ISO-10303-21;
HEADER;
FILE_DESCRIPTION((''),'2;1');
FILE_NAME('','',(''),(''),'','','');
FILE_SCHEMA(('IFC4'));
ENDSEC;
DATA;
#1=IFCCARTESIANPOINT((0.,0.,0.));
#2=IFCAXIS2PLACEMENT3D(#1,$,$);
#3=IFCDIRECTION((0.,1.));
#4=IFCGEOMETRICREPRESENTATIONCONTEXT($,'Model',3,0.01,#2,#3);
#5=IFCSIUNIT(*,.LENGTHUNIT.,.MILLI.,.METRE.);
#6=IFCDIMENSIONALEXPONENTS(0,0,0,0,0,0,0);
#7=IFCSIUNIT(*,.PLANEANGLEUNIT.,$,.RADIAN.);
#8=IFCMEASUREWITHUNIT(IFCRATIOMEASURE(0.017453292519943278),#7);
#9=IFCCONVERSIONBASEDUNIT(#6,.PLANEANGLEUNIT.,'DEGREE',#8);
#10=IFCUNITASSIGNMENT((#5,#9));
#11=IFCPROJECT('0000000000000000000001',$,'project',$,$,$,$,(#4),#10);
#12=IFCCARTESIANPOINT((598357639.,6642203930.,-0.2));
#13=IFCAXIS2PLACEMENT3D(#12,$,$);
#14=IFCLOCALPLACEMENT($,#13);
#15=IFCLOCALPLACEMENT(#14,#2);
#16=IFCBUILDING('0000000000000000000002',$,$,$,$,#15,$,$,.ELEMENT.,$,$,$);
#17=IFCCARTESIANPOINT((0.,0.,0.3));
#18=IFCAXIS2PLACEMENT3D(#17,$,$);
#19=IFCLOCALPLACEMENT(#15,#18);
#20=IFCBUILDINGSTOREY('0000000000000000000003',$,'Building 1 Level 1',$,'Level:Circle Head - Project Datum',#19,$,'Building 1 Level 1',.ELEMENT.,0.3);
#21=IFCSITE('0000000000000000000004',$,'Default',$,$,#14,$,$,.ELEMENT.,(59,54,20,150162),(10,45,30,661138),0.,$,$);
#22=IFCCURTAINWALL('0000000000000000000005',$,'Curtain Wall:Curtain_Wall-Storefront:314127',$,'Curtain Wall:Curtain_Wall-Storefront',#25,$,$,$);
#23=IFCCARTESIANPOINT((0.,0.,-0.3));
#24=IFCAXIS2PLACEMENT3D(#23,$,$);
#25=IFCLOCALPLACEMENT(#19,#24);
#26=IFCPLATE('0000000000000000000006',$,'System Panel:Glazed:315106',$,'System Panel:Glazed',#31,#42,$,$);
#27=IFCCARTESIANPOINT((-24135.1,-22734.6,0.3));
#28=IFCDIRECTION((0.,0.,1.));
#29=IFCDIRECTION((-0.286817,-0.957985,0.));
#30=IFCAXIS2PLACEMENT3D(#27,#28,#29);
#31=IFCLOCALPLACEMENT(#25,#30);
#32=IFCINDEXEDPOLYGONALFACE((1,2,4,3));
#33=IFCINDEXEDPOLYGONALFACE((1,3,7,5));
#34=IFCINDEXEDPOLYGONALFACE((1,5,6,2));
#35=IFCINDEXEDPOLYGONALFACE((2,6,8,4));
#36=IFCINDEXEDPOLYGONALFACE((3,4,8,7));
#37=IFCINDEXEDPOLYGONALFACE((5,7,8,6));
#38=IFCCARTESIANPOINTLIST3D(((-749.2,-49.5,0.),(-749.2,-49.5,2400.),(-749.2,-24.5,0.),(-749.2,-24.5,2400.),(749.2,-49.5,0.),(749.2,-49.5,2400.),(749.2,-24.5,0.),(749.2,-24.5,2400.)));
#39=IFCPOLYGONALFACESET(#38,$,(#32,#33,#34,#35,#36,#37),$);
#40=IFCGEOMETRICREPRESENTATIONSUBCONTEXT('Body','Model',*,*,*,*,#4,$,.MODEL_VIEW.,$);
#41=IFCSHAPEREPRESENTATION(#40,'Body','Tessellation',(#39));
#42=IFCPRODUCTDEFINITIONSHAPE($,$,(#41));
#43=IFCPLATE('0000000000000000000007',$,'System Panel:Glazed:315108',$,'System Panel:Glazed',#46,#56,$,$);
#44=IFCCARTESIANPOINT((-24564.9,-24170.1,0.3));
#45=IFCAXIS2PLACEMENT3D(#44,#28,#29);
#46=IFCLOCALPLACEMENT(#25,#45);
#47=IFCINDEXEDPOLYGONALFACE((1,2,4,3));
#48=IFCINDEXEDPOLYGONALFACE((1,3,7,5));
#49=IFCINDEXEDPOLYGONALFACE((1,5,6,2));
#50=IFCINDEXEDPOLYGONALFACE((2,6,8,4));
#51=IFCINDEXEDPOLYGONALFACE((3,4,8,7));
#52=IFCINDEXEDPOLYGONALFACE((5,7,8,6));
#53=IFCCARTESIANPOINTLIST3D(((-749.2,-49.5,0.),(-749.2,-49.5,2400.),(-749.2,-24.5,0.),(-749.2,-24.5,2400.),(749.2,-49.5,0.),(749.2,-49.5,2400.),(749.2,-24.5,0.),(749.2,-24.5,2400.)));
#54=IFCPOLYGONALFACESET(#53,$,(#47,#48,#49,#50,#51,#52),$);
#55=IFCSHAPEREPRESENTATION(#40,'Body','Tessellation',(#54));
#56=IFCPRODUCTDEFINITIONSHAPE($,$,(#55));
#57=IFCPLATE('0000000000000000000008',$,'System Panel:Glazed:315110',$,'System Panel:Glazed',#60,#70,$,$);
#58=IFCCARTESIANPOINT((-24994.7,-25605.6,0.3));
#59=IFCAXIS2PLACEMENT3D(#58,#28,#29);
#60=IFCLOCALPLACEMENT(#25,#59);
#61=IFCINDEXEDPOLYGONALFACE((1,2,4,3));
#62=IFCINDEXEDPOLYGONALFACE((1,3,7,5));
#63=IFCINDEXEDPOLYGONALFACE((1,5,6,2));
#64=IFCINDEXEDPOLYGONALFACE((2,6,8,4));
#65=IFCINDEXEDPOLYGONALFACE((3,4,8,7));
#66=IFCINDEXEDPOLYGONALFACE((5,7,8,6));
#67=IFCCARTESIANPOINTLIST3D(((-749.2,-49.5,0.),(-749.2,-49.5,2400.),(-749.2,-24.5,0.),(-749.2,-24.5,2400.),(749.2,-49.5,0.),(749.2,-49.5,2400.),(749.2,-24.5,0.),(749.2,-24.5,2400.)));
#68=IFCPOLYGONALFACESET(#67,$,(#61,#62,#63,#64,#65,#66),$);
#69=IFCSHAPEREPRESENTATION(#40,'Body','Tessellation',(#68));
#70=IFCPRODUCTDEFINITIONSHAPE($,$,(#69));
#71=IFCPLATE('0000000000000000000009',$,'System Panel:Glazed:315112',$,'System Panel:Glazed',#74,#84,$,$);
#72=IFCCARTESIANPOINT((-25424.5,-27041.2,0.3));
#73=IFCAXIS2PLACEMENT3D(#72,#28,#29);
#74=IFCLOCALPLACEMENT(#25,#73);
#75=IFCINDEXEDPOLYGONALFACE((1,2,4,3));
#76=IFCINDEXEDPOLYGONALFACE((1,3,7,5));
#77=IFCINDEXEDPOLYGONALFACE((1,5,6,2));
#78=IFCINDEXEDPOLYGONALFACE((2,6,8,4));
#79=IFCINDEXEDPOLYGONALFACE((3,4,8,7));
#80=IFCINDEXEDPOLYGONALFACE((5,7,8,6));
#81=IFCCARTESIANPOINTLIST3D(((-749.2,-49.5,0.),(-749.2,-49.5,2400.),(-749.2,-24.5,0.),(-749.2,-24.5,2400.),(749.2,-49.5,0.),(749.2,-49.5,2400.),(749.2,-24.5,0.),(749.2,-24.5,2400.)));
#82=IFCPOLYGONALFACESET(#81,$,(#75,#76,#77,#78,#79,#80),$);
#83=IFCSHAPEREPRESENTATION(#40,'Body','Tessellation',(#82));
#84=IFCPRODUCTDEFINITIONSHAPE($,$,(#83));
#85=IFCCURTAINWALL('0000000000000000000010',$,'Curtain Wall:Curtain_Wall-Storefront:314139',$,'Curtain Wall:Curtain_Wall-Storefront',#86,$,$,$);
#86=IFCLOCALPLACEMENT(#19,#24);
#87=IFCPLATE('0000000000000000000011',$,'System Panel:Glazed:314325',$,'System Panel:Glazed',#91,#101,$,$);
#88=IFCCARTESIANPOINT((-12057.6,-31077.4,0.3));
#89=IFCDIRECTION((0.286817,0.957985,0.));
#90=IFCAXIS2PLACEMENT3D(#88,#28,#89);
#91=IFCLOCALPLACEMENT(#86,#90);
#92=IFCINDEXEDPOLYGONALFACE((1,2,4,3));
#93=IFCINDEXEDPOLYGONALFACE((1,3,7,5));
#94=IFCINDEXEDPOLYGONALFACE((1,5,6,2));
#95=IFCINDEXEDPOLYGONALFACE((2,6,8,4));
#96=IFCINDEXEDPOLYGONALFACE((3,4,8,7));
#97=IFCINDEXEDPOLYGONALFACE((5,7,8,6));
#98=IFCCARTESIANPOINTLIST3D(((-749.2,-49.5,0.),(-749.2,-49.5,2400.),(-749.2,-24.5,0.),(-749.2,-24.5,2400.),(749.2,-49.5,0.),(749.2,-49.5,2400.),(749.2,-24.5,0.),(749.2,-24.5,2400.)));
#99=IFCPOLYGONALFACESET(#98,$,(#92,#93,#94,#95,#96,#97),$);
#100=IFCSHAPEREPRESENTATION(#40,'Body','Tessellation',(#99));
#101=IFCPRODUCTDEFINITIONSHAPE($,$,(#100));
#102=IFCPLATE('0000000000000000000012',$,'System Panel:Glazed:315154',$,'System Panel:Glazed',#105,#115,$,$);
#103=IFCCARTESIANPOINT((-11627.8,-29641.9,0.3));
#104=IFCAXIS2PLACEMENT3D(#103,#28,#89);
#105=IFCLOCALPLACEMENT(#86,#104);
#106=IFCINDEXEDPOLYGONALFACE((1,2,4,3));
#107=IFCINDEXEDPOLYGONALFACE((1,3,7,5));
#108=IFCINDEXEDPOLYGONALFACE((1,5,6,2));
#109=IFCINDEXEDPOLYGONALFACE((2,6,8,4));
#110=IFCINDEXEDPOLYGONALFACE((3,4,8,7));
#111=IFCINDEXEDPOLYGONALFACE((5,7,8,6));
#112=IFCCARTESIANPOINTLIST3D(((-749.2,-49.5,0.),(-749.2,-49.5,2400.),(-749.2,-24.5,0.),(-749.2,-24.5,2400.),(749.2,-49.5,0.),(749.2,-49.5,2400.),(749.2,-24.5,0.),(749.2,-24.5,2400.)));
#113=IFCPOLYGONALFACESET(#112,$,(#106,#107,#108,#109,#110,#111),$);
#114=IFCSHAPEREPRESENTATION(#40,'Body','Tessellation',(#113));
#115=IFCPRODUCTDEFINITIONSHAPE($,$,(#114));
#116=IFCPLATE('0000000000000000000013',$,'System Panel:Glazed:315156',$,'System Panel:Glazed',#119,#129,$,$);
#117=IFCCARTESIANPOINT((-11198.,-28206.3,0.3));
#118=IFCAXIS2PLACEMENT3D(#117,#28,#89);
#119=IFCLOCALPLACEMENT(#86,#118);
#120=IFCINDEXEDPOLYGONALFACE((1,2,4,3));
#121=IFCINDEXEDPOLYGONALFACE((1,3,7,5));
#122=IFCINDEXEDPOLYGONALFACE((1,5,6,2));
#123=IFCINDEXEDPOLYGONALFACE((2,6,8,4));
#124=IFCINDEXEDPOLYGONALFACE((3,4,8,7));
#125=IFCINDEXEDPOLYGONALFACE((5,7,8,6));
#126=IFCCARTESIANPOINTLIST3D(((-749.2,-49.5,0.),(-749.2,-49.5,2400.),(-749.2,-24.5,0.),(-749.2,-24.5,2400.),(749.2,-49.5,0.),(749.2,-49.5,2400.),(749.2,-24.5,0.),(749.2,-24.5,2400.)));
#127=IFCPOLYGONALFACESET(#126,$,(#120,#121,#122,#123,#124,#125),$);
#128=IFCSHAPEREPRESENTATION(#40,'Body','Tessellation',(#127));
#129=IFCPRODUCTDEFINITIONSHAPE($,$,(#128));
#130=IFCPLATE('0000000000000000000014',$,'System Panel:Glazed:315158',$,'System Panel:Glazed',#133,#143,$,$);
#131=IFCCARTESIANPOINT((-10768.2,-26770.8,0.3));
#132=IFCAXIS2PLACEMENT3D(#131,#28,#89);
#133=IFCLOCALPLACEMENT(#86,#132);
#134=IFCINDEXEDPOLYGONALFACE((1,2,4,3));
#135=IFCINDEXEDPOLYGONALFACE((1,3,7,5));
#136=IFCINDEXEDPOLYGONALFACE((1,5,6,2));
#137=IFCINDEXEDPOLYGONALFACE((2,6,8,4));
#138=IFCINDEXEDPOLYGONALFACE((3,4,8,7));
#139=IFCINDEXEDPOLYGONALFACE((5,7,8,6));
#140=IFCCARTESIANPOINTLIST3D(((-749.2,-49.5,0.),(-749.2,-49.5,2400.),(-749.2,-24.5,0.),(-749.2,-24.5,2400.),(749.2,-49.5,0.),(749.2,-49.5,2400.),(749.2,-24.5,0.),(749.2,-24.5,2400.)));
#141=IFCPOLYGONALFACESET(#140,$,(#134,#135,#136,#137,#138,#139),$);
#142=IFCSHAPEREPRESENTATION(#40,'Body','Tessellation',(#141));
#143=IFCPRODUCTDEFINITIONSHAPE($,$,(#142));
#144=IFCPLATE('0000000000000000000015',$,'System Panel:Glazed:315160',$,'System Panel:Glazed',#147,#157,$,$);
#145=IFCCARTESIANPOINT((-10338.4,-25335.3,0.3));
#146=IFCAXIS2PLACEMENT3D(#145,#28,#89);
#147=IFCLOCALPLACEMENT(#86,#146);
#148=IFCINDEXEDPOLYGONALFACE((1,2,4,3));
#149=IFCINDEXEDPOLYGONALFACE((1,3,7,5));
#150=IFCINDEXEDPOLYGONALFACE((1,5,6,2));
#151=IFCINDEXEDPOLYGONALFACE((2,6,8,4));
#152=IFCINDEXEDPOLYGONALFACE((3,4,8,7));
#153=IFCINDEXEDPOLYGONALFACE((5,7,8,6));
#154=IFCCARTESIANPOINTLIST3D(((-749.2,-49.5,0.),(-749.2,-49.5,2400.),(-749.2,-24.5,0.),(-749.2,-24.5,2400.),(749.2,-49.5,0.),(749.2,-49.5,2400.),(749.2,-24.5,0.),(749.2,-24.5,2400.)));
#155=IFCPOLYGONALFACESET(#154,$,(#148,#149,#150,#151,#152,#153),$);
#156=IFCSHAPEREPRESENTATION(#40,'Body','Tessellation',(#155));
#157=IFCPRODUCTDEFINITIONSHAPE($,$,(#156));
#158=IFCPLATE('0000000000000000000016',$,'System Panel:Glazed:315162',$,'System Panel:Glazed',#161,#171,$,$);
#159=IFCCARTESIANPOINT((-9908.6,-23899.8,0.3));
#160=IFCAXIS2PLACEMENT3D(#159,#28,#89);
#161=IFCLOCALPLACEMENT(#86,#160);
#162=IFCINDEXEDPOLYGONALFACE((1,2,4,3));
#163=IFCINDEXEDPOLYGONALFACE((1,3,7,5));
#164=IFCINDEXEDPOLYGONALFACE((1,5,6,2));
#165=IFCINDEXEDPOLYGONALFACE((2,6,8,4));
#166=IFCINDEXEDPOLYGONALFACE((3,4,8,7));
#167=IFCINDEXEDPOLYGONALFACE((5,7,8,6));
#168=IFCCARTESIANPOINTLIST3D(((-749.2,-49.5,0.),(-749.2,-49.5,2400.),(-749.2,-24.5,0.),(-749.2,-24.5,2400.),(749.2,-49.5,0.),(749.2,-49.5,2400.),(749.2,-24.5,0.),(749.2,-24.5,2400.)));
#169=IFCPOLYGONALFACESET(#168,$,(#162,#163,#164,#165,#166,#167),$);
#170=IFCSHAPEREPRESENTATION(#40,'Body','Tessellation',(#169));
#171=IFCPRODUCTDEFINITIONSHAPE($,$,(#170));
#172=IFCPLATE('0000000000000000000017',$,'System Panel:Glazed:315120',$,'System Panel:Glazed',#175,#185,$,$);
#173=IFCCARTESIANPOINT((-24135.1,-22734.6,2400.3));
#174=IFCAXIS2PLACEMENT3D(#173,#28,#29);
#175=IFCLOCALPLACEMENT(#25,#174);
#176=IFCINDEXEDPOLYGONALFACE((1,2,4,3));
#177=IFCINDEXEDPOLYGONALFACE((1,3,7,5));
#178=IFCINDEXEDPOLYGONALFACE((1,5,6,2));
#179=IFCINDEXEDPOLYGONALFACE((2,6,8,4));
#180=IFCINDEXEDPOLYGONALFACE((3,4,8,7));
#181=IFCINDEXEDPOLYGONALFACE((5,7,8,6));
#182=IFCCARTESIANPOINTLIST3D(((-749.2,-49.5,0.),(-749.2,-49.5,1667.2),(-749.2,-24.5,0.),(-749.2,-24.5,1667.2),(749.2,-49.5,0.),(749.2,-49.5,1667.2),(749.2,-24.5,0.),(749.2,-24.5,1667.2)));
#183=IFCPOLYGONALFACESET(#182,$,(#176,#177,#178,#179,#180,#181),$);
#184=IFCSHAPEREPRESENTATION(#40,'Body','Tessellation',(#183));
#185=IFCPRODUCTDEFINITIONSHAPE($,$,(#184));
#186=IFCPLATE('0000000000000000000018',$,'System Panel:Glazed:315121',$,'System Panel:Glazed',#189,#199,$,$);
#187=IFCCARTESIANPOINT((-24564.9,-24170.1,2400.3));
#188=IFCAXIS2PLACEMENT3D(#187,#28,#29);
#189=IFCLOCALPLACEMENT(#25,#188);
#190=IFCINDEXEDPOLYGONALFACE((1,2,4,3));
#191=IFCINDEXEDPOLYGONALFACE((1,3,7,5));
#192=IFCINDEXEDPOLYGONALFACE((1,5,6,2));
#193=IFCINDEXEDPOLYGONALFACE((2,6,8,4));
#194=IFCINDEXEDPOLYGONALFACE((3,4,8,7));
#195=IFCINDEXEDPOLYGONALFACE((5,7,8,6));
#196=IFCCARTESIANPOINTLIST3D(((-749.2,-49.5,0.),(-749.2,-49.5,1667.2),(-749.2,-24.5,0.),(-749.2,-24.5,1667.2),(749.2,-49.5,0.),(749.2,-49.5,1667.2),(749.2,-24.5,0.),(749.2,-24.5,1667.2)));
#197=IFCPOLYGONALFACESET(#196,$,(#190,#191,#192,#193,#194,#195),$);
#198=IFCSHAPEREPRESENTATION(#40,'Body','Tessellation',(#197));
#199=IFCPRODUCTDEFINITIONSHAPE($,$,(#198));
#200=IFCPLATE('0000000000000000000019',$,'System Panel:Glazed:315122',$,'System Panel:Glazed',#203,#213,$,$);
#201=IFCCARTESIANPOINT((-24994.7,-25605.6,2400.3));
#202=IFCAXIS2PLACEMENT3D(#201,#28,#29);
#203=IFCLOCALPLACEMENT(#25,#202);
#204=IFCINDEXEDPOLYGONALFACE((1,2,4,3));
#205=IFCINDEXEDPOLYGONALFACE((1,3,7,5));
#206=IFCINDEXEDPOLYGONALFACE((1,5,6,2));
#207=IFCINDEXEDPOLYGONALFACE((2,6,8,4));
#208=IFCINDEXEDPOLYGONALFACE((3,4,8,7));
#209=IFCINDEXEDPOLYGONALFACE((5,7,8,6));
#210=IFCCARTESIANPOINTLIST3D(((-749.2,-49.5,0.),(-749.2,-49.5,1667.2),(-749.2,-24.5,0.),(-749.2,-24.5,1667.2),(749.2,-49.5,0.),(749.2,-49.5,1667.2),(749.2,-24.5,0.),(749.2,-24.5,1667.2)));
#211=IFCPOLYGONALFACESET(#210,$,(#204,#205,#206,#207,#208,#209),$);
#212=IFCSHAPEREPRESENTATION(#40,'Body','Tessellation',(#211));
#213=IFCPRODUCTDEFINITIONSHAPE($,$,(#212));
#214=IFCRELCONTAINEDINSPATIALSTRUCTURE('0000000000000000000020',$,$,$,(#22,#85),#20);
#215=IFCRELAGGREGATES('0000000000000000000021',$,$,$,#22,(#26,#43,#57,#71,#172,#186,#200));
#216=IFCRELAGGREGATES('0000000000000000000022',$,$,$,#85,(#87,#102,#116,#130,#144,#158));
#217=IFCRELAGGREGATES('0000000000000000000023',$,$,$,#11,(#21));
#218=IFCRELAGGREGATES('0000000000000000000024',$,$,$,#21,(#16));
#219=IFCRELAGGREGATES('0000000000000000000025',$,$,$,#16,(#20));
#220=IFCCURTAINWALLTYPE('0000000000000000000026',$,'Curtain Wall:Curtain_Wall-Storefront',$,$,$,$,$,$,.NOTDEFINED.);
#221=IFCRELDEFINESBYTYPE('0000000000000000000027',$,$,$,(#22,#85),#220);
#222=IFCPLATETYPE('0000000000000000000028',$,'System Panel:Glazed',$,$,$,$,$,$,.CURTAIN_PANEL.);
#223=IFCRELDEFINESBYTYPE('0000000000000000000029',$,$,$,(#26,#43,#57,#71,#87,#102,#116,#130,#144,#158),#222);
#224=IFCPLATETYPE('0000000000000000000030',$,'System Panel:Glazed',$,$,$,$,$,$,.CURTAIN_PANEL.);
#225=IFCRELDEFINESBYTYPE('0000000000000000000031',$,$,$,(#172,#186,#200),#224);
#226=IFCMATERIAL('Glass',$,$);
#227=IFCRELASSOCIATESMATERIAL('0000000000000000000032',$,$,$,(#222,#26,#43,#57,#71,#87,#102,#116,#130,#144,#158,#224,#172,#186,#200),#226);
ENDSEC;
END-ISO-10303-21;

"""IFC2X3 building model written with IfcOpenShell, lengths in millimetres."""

from ifc_helpers import new_model, entity, si_unit, converted_unit, direction, frame, frame_2d, origin, place, context, subcontext, project, spatial, rectangle, extrude, source, transform, mapped, material, type_object, type_shapes, element, aggregate, save


model = new_model("IFC2X3")

# Units and contexts
model_context = context("Model", 3, precision=0.01, world=origin(), true_north=direction((0.0, 1.0)))
body_context = subcontext(model_context, "Body", "Model", "MODEL_VIEW")
ifc_project = project(units=[si_unit("LENGTHUNIT", "METRE", prefix="MILLI"), converted_unit("PLANEANGLEUNIT", "DEGREE", entity("IfcRatioMeasure", 0.017453292519943278), si_unit("PLANEANGLEUNIT", "RADIAN"), dimensions=[0, 0, 0, 0, 0, 0, 0])], contexts=[model_context])

# Site, building, storey
site_placement = place(None, frame((598357639.0, 6642203930.0, -0.2)))
site = spatial("IfcSite", under=ifc_project, at=site_placement, Name="Default", CompositionType="ELEMENT", RefLatitude=(59, 54, 20, 150162), RefLongitude=(10, 45, 30, 661138), RefElevation=0.0)
building_placement = place(site_placement, origin())
building = spatial("IfcBuilding", under=site, at=building_placement, CompositionType="ELEMENT")
storey_placement = place(building_placement, frame((0.0, 0.0, 0.3)))
storey = spatial("IfcBuildingStorey", under=building, at=storey_placement, Name="Building 1 Level 1", ObjectType="Level:Circle Head - Project Datum", LongName="Building 1 Level 1", CompositionType="ELEMENT", Elevation=0.3)

# Curtain walls, plates
curtain_wall_type = type_object("IfcCurtainWallType", Name="Curtain Wall:Curtain_Wall-Storefront", PredefinedType="NOTDEFINED")
curtain_wall_1_placement = place(storey_placement, frame((0.0, 0.0, -0.3)))
curtain_wall_1 = element("IfcCurtainWall", 1, at=curtain_wall_1_placement, inside=storey, type_object=curtain_wall_type, Name="Curtain Wall:Curtain_Wall-Storefront:314127", ObjectType="Curtain Wall:Curtain_Wall-Storefront")
ifc_material = material(Name="Glass")
plate_type_1 = type_object("IfcPlateType", Name="System Panel:Glazed", PredefinedType="CURTAIN_PANEL", material=ifc_material)
shared_shape_1 = source(origin(), body_context, "Body", "SweptSolid", [
    extrude(rectangle(XDim=25.0, YDim=1498.5, at=frame_2d((0.0, 0.0), x_axis=(1.0, 0.0))), frame((0.0, -37.0, 0.0), z_axis=(0.0, 0.0, 1.0), x_axis=(0.0, 1.0, 0.0)), (0.0, 0.0, 1.0), 2400.0),
])
type_shapes(plate_type_1, [shared_shape_1])
plate_1_placement = place(curtain_wall_1_placement, frame((-24135.1, -22734.6, 0.3), z_axis=(0.0, 0.0, 1.0), x_axis=(-0.286817, -0.957985, 0.0)))
plate_1 = element("IfcPlate", 2, at=plate_1_placement, type_object=plate_type_1, material=ifc_material, Name="System Panel:Glazed:315106", ObjectType="System Panel:Glazed", context=body_context, shape_type="MappedRepresentation", body=[
    mapped(shared_shape_1, transform((0.0, 0.0, 0.0), scale=1.0)),
])
plate_2_placement = place(curtain_wall_1_placement, frame((-24564.9, -24170.1, 0.3), z_axis=(0.0, 0.0, 1.0), x_axis=(-0.286817, -0.957985, 0.0)))
plate_2 = element("IfcPlate", 3, at=plate_2_placement, type_object=plate_type_1, material=ifc_material, Name="System Panel:Glazed:315108", ObjectType="System Panel:Glazed", context=body_context, shape_type="MappedRepresentation", body=[
    mapped(shared_shape_1, transform((0.0, 0.0, 0.0), scale=1.0)),
])
plate_3_placement = place(curtain_wall_1_placement, frame((-24994.7, -25605.6, 0.3), z_axis=(0.0, 0.0, 1.0), x_axis=(-0.286817, -0.957985, 0.0)))
plate_3 = element("IfcPlate", 4, at=plate_3_placement, type_object=plate_type_1, material=ifc_material, Name="System Panel:Glazed:315110", ObjectType="System Panel:Glazed", context=body_context, shape_type="MappedRepresentation", body=[
    mapped(shared_shape_1, transform((0.0, 0.0, 0.0), scale=1.0)),
])
plate_4_placement = place(curtain_wall_1_placement, frame((-25424.5, -27041.2, 0.3), z_axis=(0.0, 0.0, 1.0), x_axis=(-0.286817, -0.957985, 0.0)))
plate_4 = element("IfcPlate", 5, at=plate_4_placement, type_object=plate_type_1, material=ifc_material, Name="System Panel:Glazed:315112", ObjectType="System Panel:Glazed", context=body_context, shape_type="MappedRepresentation", body=[
    mapped(shared_shape_1, transform((0.0, 0.0, 0.0), scale=1.0)),
])
curtain_wall_2_placement = place(storey_placement, frame((0.0, 0.0, -0.3)))
curtain_wall_2 = element("IfcCurtainWall", 6, at=curtain_wall_2_placement, inside=storey, type_object=curtain_wall_type, Name="Curtain Wall:Curtain_Wall-Storefront:314139", ObjectType="Curtain Wall:Curtain_Wall-Storefront")
plate_5_placement = place(curtain_wall_2_placement, frame((-12057.6, -31077.4, 0.3), z_axis=(0.0, 0.0, 1.0), x_axis=(0.286817, 0.957985, 0.0)))
plate_5 = element("IfcPlate", 7, at=plate_5_placement, type_object=plate_type_1, material=ifc_material, Name="System Panel:Glazed:314325", ObjectType="System Panel:Glazed", context=body_context, shape_type="MappedRepresentation", body=[
    mapped(shared_shape_1, transform((0.0, 0.0, 0.0), scale=1.0)),
])
plate_6_placement = place(curtain_wall_2_placement, frame((-11627.8, -29641.9, 0.3), z_axis=(0.0, 0.0, 1.0), x_axis=(0.286817, 0.957985, 0.0)))
plate_6 = element("IfcPlate", 8, at=plate_6_placement, type_object=plate_type_1, material=ifc_material, Name="System Panel:Glazed:315154", ObjectType="System Panel:Glazed", context=body_context, shape_type="MappedRepresentation", body=[
    mapped(shared_shape_1, transform((0.0, 0.0, 0.0), scale=1.0)),
])
plate_7_placement = place(curtain_wall_2_placement, frame((-11198.0, -28206.3, 0.3), z_axis=(0.0, 0.0, 1.0), x_axis=(0.286817, 0.957985, 0.0)))
plate_7 = element("IfcPlate", 9, at=plate_7_placement, type_object=plate_type_1, material=ifc_material, Name="System Panel:Glazed:315156", ObjectType="System Panel:Glazed", context=body_context, shape_type="MappedRepresentation", body=[
    mapped(shared_shape_1, transform((0.0, 0.0, 0.0), scale=1.0)),
])
plate_8_placement = place(curtain_wall_2_placement, frame((-10768.2, -26770.8, 0.3), z_axis=(0.0, 0.0, 1.0), x_axis=(0.286817, 0.957985, 0.0)))
plate_8 = element("IfcPlate", 10, at=plate_8_placement, type_object=plate_type_1, material=ifc_material, Name="System Panel:Glazed:315158", ObjectType="System Panel:Glazed", context=body_context, shape_type="MappedRepresentation", body=[
    mapped(shared_shape_1, transform((0.0, 0.0, 0.0), scale=1.0)),
])
plate_9_placement = place(curtain_wall_2_placement, frame((-10338.4, -25335.3, 0.3), z_axis=(0.0, 0.0, 1.0), x_axis=(0.286817, 0.957985, 0.0)))
plate_9 = element("IfcPlate", 11, at=plate_9_placement, type_object=plate_type_1, material=ifc_material, Name="System Panel:Glazed:315160", ObjectType="System Panel:Glazed", context=body_context, shape_type="MappedRepresentation", body=[
    mapped(shared_shape_1, transform((0.0, 0.0, 0.0), scale=1.0)),
])
plate_10_placement = place(curtain_wall_2_placement, frame((-9908.6, -23899.8, 0.3), z_axis=(0.0, 0.0, 1.0), x_axis=(0.286817, 0.957985, 0.0)))
plate_10 = element("IfcPlate", 12, at=plate_10_placement, type_object=plate_type_1, material=ifc_material, Name="System Panel:Glazed:315162", ObjectType="System Panel:Glazed", context=body_context, shape_type="MappedRepresentation", body=[
    mapped(shared_shape_1, transform((0.0, 0.0, 0.0), scale=1.0)),
])

# Plates
plate_type_2 = type_object("IfcPlateType", Name="System Panel:Glazed", PredefinedType="CURTAIN_PANEL", material=ifc_material)
shared_shape_2 = source(origin(), body_context, "Body", "SweptSolid", [
    extrude(rectangle(XDim=25.0, YDim=1498.5, at=frame_2d((0.0, 0.0), x_axis=(1.0, 0.0))), frame((0.0, -37.0, 0.0), z_axis=(0.0, 0.0, 1.0), x_axis=(0.0, 1.0, 0.0)), (0.0, 0.0, 1.0), 1667.2),
])
type_shapes(plate_type_2, [shared_shape_2])
plate_11_placement = place(curtain_wall_1_placement, frame((-24135.1, -22734.6, 2400.3), z_axis=(0.0, 0.0, 1.0), x_axis=(-0.286817, -0.957985, 0.0)))
plate_11 = element("IfcPlate", 13, at=plate_11_placement, type_object=plate_type_2, material=ifc_material, Name="System Panel:Glazed:315120", ObjectType="System Panel:Glazed", context=body_context, shape_type="MappedRepresentation", body=[
    mapped(shared_shape_2, transform((0.0, 0.0, 0.0), scale=1.0)),
])
plate_12_placement = place(curtain_wall_1_placement, frame((-24564.9, -24170.1, 2400.3), z_axis=(0.0, 0.0, 1.0), x_axis=(-0.286817, -0.957985, 0.0)))
plate_12 = element("IfcPlate", 14, at=plate_12_placement, type_object=plate_type_2, material=ifc_material, Name="System Panel:Glazed:315121", ObjectType="System Panel:Glazed", context=body_context, shape_type="MappedRepresentation", body=[
    mapped(shared_shape_2, transform((0.0, 0.0, 0.0), scale=1.0)),
])
plate_13_placement = place(curtain_wall_1_placement, frame((-24994.7, -25605.6, 2400.3), z_axis=(0.0, 0.0, 1.0), x_axis=(-0.286817, -0.957985, 0.0)))
plate_13 = element("IfcPlate", 15, at=plate_13_placement, type_object=plate_type_2, material=ifc_material, Name="System Panel:Glazed:315122", ObjectType="System Panel:Glazed", context=body_context, shape_type="MappedRepresentation", body=[
    mapped(shared_shape_2, transform((0.0, 0.0, 0.0), scale=1.0)),
])
aggregate(curtain_wall_1, [plate_1, plate_2, plate_3, plate_4, plate_11, plate_12, plate_13])
aggregate(curtain_wall_2, [plate_5, plate_6, plate_7, plate_8, plate_9, plate_10])

save(model, "model.ifc")
